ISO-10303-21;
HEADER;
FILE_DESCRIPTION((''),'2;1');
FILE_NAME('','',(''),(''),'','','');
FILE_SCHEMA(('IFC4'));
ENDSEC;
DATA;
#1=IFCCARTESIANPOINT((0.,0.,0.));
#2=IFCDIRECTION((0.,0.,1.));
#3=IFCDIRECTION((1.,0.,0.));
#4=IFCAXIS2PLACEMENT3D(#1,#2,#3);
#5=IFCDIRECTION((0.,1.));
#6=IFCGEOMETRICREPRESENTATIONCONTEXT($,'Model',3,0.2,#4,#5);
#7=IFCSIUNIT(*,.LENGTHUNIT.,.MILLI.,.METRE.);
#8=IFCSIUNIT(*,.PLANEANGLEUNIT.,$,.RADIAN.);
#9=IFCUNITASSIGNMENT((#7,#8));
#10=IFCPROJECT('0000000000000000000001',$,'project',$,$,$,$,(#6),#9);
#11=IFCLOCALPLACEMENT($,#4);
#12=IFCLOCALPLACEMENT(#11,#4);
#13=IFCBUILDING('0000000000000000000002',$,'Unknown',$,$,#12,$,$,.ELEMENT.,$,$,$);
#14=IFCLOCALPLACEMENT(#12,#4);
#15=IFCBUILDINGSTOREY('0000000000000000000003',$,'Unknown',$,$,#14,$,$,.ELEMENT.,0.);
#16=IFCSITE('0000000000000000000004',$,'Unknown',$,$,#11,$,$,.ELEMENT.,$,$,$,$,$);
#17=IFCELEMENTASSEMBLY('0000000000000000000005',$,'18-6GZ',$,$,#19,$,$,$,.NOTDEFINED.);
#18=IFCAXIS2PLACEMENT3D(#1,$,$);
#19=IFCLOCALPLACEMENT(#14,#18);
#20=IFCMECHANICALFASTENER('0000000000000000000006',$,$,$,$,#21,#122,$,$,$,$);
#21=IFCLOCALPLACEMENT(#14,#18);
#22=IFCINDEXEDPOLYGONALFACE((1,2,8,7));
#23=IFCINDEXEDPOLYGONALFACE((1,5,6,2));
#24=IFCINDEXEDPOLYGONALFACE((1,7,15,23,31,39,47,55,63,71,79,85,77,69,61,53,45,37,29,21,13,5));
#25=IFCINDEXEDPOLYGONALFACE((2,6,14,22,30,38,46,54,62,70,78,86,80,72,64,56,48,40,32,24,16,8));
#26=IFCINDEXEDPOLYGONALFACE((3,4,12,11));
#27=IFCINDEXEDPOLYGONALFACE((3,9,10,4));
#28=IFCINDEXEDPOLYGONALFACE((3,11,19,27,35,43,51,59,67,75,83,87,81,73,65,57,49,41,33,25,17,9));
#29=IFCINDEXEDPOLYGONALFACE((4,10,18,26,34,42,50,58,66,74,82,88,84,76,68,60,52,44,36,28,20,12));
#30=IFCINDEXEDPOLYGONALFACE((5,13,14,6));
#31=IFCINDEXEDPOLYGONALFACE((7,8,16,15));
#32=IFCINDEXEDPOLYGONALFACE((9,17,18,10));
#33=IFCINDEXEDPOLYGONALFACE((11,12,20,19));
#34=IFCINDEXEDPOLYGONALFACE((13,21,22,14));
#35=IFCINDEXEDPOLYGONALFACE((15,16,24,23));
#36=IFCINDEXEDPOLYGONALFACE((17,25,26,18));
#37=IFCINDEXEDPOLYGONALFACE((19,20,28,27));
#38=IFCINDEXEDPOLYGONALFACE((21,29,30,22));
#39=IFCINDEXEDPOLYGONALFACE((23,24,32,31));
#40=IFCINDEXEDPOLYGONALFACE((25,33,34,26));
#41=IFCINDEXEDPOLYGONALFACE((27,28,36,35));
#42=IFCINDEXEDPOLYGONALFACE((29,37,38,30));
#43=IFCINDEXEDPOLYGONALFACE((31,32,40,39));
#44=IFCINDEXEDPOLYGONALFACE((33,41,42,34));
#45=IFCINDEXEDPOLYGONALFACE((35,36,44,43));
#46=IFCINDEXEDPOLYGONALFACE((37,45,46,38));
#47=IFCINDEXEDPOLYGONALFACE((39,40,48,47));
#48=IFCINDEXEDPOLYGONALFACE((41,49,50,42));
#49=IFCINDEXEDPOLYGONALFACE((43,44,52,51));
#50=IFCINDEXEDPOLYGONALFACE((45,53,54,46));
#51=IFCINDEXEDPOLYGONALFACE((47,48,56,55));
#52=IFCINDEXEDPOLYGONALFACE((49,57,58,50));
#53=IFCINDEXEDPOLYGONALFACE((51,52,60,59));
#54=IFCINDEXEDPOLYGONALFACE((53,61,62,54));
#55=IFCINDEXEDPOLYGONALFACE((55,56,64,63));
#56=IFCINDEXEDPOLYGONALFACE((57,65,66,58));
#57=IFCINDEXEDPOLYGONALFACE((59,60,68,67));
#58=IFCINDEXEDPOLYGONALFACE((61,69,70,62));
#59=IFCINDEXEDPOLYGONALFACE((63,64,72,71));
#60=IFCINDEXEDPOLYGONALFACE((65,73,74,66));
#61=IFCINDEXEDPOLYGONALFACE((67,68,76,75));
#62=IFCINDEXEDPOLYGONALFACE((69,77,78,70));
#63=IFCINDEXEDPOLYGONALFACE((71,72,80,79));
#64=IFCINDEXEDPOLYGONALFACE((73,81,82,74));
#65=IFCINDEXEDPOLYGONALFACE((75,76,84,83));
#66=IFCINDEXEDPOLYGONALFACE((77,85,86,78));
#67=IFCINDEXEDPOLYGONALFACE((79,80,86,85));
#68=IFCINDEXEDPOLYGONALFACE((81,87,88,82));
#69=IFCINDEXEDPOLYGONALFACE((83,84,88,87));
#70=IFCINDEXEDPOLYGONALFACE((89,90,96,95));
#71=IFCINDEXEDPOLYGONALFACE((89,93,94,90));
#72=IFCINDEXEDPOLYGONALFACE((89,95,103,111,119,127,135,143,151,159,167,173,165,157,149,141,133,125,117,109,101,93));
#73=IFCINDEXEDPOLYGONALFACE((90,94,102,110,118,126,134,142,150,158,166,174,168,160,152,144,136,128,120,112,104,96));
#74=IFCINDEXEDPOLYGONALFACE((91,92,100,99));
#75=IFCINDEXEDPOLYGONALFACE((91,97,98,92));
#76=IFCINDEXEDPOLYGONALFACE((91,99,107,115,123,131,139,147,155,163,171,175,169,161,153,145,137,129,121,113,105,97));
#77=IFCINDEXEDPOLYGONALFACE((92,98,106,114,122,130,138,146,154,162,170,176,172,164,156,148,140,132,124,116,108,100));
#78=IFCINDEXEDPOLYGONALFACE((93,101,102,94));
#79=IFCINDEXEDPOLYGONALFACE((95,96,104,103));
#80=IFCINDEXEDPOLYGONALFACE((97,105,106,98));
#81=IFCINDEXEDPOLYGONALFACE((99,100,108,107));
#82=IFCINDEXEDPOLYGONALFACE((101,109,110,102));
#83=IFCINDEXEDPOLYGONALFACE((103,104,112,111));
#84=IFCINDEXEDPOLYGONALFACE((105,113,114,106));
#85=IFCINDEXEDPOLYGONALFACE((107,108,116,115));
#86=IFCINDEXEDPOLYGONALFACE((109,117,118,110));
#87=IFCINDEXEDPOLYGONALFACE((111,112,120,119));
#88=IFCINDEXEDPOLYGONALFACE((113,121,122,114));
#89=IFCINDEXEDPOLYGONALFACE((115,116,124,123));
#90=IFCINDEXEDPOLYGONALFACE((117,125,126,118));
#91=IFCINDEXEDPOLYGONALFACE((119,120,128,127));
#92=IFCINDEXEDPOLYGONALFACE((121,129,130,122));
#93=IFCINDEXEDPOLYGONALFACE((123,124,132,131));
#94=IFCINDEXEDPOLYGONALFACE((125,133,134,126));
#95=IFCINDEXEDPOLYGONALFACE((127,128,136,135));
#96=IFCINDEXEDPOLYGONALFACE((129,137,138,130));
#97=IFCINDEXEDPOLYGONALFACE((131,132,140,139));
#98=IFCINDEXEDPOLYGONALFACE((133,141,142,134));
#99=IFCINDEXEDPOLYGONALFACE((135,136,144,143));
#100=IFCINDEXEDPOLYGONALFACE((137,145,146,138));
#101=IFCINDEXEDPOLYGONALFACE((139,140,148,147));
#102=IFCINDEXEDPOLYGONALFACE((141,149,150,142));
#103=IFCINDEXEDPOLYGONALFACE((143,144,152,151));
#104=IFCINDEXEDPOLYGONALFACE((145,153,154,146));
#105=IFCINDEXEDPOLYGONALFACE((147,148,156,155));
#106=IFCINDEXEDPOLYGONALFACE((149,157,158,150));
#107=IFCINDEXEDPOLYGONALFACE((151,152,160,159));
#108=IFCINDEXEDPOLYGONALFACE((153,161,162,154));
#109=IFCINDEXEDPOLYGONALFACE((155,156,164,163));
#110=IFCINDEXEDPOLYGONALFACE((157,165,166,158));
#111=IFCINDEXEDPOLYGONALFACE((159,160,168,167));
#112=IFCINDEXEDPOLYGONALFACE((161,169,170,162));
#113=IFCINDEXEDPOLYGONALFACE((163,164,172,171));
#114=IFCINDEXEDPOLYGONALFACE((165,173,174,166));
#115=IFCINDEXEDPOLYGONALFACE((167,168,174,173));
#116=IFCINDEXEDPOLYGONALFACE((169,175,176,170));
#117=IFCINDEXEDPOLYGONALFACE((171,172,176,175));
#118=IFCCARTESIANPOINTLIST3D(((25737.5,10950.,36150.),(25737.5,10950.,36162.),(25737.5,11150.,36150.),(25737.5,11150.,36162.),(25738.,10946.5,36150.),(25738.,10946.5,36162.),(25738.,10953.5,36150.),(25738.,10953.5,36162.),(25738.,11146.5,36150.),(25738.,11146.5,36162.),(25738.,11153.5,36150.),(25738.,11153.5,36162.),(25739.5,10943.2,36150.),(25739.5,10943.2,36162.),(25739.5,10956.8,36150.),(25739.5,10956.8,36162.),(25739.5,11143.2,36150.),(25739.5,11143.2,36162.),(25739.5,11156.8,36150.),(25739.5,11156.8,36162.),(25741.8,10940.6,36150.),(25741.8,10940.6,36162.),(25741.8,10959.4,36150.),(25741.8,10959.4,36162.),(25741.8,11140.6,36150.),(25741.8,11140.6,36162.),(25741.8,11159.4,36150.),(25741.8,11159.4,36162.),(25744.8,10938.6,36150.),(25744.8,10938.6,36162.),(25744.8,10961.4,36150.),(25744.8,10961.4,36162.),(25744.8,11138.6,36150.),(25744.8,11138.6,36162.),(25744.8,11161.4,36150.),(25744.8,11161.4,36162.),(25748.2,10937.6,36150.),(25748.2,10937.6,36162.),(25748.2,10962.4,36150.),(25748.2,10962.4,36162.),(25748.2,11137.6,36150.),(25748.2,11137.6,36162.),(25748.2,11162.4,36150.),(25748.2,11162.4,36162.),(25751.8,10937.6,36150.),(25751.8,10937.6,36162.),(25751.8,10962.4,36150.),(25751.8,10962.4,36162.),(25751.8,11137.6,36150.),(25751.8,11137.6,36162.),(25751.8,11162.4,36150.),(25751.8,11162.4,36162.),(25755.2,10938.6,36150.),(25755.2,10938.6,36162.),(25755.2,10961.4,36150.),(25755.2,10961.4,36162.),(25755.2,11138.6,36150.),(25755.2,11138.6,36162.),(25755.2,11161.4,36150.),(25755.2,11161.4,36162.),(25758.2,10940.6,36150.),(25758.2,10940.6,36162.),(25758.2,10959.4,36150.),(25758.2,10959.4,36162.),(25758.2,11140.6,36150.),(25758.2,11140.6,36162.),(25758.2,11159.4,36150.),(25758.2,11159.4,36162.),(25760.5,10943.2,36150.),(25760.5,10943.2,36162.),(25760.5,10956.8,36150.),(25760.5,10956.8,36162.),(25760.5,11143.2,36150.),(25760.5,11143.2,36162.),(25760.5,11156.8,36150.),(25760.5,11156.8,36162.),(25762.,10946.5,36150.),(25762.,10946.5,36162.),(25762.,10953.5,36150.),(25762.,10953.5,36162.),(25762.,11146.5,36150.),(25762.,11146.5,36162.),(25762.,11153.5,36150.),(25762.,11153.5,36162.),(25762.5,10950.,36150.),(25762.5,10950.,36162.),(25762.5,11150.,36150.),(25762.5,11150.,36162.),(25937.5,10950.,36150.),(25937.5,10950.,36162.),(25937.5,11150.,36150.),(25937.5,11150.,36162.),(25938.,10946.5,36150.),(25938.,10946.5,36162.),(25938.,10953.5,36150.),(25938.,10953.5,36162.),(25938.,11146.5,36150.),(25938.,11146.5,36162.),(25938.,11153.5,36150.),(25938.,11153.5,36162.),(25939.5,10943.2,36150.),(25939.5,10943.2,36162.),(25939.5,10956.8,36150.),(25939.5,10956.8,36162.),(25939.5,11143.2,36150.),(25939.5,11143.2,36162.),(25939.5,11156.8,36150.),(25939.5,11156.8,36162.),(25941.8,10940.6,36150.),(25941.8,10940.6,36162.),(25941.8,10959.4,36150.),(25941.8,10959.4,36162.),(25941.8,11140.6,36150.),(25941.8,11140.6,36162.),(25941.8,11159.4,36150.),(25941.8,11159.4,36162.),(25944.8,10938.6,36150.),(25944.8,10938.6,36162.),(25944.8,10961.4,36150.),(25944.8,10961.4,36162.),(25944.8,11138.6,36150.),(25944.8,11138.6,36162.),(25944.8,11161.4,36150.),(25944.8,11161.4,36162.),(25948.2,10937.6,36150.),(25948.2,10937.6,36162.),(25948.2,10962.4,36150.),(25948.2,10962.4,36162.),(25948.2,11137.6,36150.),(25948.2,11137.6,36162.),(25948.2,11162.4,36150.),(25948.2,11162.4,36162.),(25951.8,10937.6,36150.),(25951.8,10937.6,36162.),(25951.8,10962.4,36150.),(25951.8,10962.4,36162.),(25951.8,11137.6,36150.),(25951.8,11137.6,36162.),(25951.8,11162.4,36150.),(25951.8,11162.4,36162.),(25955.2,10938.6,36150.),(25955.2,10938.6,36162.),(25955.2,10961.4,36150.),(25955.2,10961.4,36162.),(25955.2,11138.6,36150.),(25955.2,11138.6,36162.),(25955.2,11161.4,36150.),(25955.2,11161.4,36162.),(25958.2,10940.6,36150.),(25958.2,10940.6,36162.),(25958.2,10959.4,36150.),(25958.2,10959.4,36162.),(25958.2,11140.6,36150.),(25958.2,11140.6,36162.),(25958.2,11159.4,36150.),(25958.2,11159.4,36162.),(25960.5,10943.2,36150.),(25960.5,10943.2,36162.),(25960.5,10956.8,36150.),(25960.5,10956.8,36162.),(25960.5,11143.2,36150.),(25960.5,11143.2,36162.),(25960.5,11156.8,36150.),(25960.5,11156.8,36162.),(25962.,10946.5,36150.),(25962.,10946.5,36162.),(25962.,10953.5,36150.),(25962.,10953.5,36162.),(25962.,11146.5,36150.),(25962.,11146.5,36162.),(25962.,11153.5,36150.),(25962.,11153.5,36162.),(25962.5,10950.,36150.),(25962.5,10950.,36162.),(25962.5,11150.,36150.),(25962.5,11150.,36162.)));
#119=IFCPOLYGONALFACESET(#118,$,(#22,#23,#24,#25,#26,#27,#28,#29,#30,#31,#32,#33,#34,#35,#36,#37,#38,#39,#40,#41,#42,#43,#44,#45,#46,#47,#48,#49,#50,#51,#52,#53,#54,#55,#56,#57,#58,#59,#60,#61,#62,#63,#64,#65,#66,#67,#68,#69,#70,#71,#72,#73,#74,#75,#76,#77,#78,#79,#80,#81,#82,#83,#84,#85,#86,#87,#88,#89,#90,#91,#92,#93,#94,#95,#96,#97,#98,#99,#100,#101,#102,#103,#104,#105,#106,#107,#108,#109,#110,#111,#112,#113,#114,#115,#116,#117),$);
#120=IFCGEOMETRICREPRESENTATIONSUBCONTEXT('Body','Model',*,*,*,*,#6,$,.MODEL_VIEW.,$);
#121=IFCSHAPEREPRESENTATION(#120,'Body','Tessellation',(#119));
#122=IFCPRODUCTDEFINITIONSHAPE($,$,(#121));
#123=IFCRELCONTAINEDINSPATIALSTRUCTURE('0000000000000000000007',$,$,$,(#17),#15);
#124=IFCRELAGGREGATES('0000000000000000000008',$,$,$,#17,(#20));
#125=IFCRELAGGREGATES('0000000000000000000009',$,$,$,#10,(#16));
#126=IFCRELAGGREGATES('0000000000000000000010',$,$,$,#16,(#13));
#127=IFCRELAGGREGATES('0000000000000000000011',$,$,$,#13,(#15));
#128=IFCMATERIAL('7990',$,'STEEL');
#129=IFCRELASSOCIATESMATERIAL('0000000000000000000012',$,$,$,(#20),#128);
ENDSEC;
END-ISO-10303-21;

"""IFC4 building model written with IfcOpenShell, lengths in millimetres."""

from ifc_helpers import new_model, si_unit, direction, frame, origin_with_axes, place, context, subcontext, project, spatial, arc, indexed_curve, outline, extrude, source, transform, mapped, material, element, aggregate, save


model = new_model("IFC4")

# Units and contexts
model_context = context("Model", 3, precision=0.2, world=origin_with_axes(), true_north=direction((0.0, 1.0)))
body_context = subcontext(model_context, "Body", "Model", "MODEL_VIEW")
ifc_project = project(units=[si_unit("LENGTHUNIT", "METRE", prefix="MILLI"), si_unit("PLANEANGLEUNIT", "RADIAN")], contexts=[model_context])

# Site, building, storey
site_placement = place(None, origin_with_axes())
site = spatial("IfcSite", under=ifc_project, at=site_placement, Name="Unknown", CompositionType="ELEMENT")
building_placement = place(site_placement, origin_with_axes())
building = spatial("IfcBuilding", under=site, at=building_placement, Name="Unknown", CompositionType="ELEMENT")
storey_placement = place(building_placement, origin_with_axes())
storey = spatial("IfcBuildingStorey", under=building, at=storey_placement, Name="Unknown", CompositionType="ELEMENT", Elevation=0.0)

# Element assembly
assembly_1_placement = place(storey_placement, frame((25850.0, 11050.0, 35950.0), z_axis=(-1.0, 0.0, 0.0), x_axis=(0.0, 0.0, 1.0)))
assembly_1 = element("IfcElementAssembly", 1, at=assembly_1_placement, inside=storey, Name="18-6GZ", PredefinedType="NOTDEFINED")

# Mechanical fastener
ifc_material_1 = material(Name="7990", Category="STEEL")
placement_1 = place(assembly_1_placement, frame((212.0, 0.0, 0.0), z_axis=(1.0, 0.0, 0.0), x_axis=(0.0, 1.0, 0.0)))
shared_shape_1 = source(origin_with_axes(), body_context, "Body", "SweptSolid", [
    extrude(outline(indexed_curve([(12.5, 0.0), (0.0, 12.5), (-12.5, 0.0), (0.0, -12.5)], segments=[arc(1, 2, 3), arc(3, 4, 1)])), frame((0.0, 0.0, 0.0), z_axis=(0.0, 0.0, -1.0), x_axis=(0.0, 1.0, 0.0)), (0.0, 0.0, 1.0), 12.0),
])
mechanical_fastener_1 = element("IfcMechanicalFastener", 2, at=placement_1, material=ifc_material_1, context=body_context, shape_type="MappedRepresentation", body=[
    mapped(shared_shape_1, transform((-100.0, -100.0, 0.0))),
    mapped(shared_shape_1, transform((100.0, -100.0, 0.0))),
    mapped(shared_shape_1, transform((-100.0, 100.0, 0.0))),
    mapped(shared_shape_1, transform((100.0, 100.0, 0.0))),
])
aggregate(assembly_1, [mechanical_fastener_1])

save(model, "model.ifc")
